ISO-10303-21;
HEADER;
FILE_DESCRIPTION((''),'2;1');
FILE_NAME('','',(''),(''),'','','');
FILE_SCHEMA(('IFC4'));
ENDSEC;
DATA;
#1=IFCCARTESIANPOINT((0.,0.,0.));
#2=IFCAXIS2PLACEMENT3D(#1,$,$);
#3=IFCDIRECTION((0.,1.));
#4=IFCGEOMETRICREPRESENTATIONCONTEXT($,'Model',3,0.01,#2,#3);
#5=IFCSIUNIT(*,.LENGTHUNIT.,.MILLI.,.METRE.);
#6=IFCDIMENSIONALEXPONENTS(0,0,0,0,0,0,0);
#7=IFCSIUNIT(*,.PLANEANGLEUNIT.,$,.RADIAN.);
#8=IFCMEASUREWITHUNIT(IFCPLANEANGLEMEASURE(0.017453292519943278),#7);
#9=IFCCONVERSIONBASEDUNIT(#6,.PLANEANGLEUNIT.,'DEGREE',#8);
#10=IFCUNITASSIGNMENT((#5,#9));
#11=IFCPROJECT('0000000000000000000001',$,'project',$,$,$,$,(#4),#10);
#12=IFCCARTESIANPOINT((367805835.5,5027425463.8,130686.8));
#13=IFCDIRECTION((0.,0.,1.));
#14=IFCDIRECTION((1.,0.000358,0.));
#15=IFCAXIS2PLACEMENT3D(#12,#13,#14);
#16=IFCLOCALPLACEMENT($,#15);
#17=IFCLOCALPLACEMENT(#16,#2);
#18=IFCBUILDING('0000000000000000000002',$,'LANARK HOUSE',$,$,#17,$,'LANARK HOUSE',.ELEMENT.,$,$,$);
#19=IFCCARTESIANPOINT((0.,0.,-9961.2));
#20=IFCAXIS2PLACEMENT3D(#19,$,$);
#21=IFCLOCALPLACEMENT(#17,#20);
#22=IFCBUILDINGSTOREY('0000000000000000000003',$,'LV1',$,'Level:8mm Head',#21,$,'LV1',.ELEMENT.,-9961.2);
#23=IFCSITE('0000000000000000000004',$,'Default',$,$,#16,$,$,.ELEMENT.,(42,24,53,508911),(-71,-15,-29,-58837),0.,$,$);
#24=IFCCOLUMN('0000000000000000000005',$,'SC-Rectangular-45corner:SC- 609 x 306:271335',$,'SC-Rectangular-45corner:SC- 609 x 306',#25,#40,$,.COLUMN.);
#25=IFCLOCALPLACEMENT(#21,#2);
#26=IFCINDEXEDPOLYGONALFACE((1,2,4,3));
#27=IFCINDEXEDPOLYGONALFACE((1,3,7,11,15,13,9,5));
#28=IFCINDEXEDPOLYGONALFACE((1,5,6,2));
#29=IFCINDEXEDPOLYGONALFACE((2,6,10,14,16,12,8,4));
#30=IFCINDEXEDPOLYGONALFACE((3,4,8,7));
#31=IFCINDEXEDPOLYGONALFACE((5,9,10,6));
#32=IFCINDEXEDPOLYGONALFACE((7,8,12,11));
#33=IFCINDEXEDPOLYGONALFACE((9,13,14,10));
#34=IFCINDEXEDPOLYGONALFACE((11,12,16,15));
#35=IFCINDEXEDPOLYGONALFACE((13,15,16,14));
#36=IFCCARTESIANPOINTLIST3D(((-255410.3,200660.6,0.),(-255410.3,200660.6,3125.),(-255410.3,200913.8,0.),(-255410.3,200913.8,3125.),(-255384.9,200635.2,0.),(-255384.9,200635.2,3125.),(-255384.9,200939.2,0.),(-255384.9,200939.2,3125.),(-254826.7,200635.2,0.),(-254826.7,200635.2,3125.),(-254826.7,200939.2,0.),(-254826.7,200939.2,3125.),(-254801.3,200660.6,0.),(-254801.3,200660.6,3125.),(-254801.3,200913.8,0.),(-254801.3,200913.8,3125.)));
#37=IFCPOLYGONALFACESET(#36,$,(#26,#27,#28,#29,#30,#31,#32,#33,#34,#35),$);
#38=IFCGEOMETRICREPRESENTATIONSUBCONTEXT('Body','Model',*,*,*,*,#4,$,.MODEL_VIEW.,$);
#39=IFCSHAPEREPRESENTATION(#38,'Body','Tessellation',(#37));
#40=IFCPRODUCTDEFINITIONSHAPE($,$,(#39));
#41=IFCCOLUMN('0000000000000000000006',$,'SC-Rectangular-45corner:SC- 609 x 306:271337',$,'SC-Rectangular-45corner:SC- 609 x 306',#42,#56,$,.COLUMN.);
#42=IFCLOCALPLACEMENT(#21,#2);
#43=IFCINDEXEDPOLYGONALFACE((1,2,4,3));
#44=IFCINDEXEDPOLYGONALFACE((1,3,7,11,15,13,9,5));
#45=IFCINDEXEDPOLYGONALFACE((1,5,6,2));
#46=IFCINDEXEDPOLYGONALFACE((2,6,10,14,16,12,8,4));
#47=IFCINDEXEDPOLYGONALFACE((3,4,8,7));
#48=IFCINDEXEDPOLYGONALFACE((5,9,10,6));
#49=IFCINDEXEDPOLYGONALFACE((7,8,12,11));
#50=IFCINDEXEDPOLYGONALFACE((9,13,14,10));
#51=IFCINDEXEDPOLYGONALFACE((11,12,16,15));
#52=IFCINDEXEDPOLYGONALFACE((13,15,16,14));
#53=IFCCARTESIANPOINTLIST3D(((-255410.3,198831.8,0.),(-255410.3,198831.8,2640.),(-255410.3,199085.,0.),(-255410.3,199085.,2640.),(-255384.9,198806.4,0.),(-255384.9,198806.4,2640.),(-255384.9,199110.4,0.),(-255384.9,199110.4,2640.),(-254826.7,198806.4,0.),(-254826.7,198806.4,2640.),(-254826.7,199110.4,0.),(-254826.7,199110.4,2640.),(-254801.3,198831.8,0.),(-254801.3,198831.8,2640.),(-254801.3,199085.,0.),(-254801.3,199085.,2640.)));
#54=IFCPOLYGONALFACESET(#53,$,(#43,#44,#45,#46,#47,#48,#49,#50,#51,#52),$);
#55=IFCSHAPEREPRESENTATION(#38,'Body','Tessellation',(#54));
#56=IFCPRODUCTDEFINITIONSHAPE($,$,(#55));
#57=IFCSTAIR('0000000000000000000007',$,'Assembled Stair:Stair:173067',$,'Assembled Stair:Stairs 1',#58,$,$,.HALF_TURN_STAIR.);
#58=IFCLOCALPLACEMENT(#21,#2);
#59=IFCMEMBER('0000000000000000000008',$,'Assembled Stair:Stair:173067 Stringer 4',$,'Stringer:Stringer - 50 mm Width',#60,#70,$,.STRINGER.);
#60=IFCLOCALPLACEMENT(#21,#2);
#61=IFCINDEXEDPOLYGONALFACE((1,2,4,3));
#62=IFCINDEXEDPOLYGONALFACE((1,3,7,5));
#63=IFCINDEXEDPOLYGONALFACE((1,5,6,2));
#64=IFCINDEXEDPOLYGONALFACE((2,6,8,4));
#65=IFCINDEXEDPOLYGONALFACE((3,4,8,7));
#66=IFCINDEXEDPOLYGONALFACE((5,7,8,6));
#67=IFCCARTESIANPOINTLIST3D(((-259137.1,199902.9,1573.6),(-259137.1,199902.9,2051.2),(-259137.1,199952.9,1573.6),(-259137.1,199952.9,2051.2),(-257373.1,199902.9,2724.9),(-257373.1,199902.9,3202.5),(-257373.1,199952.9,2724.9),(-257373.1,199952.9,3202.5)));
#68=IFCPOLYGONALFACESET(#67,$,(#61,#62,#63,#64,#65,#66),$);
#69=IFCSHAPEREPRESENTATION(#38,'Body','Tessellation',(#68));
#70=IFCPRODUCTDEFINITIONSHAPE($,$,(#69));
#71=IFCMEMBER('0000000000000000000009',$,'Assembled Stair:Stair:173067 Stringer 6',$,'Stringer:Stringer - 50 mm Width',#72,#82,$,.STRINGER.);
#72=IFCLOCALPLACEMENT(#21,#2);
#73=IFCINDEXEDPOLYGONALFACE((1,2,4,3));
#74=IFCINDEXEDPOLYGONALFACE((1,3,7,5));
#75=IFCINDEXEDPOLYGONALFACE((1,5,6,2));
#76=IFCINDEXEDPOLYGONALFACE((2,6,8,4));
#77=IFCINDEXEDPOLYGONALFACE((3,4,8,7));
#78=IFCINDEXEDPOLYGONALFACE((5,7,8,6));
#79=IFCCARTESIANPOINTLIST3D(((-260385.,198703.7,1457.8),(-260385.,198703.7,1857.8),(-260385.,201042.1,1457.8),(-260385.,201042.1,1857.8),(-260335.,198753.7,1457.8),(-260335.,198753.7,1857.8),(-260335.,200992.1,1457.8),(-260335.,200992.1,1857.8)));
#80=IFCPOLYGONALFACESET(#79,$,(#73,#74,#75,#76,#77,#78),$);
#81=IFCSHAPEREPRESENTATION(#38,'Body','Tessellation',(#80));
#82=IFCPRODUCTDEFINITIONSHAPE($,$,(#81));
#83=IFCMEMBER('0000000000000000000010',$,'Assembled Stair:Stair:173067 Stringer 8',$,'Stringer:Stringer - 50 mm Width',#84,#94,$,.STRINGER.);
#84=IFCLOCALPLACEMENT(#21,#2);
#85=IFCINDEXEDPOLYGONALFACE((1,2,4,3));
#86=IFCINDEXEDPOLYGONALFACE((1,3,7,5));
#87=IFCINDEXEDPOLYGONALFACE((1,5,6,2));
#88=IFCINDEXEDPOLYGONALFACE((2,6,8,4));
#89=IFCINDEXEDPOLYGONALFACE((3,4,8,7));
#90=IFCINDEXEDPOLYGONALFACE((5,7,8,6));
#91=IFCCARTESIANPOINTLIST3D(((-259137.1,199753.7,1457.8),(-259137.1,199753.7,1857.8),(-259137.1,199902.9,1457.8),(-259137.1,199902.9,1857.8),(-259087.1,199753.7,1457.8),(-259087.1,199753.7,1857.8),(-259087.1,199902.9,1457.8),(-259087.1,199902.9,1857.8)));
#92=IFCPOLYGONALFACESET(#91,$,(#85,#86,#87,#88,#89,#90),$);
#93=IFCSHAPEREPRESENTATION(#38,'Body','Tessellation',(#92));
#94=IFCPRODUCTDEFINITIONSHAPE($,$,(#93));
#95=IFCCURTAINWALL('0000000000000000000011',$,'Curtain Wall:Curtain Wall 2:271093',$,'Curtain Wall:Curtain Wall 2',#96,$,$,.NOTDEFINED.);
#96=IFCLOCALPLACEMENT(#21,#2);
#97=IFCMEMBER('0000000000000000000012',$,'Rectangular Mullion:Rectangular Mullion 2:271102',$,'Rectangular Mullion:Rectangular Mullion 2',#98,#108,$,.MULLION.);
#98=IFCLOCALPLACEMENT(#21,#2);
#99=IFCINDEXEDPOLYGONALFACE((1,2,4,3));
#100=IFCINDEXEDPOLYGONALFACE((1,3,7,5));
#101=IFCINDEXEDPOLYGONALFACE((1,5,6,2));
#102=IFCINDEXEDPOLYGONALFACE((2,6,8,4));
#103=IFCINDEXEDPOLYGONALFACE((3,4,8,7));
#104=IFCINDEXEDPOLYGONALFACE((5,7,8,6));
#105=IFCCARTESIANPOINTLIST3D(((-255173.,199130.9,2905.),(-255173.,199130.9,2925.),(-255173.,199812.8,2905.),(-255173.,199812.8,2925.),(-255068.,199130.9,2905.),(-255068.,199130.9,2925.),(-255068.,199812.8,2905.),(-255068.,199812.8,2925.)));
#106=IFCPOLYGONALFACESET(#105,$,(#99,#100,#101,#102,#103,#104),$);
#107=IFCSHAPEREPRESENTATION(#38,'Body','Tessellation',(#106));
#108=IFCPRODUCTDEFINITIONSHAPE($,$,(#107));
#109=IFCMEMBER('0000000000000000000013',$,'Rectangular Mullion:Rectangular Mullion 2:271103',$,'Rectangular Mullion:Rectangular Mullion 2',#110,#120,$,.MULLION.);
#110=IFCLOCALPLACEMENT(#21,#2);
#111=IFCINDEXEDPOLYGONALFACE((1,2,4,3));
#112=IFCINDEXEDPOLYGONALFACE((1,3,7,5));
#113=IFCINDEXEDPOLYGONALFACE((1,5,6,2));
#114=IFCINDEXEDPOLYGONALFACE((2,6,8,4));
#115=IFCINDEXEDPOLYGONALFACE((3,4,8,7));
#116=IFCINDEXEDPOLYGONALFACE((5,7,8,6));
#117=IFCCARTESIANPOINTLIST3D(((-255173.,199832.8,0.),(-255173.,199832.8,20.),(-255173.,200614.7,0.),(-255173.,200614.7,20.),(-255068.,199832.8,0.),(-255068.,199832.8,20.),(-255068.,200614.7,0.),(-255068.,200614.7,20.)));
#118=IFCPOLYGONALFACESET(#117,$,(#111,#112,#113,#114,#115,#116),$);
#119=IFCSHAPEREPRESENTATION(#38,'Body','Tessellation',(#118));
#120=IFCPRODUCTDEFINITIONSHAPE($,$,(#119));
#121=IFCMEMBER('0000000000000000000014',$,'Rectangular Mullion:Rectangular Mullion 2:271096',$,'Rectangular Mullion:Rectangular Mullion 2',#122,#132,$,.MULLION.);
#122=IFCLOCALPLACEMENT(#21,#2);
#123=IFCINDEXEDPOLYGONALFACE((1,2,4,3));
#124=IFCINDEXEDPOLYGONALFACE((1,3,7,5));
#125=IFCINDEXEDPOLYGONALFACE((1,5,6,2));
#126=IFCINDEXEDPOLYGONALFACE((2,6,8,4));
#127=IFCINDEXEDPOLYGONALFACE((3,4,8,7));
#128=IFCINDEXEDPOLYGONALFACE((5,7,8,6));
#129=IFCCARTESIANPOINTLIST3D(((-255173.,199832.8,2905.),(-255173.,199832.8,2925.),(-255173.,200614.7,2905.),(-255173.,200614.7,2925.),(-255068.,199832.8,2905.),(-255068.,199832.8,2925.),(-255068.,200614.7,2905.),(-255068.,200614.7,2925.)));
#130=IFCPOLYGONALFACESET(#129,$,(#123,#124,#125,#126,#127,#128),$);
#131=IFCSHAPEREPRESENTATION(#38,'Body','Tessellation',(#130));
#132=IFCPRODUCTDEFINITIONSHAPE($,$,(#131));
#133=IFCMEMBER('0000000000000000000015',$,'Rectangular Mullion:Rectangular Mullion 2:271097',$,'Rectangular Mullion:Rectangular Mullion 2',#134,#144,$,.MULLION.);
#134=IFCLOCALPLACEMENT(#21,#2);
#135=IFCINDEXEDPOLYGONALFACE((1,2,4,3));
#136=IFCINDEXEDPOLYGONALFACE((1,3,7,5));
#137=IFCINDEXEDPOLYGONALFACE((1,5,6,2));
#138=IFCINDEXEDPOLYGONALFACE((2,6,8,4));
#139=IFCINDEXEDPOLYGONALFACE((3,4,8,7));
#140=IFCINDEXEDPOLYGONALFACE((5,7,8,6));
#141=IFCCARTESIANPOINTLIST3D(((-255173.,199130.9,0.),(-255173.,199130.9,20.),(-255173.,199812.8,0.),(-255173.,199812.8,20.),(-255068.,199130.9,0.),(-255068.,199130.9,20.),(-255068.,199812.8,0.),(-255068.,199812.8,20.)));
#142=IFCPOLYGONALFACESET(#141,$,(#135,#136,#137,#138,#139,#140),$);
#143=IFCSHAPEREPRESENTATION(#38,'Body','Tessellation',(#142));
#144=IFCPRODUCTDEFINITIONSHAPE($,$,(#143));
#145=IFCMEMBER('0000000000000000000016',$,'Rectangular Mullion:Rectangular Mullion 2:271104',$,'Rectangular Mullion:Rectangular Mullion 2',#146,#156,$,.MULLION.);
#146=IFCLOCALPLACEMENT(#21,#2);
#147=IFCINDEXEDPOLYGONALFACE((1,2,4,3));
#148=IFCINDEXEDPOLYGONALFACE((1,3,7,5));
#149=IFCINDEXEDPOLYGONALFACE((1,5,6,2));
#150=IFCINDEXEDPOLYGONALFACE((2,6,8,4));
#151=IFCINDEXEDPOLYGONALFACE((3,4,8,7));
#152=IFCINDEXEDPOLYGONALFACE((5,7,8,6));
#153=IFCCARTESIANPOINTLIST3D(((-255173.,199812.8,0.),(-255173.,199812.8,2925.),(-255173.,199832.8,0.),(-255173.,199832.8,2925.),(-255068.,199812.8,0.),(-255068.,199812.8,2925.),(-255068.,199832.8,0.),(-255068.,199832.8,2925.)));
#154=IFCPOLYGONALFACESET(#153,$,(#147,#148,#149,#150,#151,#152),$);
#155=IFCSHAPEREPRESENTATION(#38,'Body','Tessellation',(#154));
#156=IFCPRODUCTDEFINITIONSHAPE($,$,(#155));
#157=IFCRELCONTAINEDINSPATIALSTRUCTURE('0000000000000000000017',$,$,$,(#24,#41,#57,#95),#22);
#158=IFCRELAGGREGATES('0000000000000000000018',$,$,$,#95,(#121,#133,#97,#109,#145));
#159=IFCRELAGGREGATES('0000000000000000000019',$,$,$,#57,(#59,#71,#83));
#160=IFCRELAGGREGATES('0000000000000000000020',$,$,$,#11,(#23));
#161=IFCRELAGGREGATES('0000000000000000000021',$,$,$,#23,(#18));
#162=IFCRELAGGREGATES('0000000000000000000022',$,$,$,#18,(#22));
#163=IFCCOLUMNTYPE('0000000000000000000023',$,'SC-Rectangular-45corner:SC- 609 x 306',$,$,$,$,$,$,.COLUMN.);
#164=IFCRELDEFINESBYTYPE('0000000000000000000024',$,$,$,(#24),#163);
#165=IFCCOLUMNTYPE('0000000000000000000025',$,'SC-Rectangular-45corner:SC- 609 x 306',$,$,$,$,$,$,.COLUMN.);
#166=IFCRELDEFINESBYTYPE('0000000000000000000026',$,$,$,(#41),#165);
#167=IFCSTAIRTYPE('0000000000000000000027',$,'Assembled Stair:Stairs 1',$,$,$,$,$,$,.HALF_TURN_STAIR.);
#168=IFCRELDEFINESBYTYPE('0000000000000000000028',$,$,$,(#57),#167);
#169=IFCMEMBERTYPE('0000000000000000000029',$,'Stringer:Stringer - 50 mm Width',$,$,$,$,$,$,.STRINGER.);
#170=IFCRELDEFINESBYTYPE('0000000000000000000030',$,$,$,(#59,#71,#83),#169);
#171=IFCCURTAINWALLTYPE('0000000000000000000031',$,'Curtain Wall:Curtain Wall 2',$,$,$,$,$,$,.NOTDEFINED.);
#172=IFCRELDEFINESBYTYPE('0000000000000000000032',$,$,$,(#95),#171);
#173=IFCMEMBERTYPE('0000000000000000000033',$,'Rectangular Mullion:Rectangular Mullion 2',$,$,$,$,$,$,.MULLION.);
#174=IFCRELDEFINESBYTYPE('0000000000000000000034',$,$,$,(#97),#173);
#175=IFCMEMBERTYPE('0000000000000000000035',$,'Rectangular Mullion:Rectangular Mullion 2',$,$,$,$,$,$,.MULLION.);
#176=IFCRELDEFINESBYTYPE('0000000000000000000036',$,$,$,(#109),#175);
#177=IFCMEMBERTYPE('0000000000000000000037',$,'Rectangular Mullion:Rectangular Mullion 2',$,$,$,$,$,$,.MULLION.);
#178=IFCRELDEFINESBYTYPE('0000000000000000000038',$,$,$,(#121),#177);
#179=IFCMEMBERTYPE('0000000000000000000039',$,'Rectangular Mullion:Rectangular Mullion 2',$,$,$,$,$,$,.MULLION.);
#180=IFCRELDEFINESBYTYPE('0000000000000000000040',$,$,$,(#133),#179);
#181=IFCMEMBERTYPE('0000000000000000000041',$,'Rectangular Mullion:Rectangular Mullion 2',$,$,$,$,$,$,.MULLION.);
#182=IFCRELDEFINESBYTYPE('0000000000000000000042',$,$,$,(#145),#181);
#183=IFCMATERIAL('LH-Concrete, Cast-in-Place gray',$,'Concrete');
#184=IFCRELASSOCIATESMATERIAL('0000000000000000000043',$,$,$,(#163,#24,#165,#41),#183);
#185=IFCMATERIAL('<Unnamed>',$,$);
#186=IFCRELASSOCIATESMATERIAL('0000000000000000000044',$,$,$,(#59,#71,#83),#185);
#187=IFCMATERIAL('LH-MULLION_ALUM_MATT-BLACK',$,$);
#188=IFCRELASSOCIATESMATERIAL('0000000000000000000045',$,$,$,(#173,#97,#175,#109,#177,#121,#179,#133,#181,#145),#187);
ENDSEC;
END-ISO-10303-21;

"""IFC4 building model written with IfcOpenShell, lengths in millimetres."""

from ifc_helpers import new_model, entity, si_unit, converted_unit, direction, frame, origin, place, context, subcontext, project, spatial, indexed_curve, outline, extrude, source, transform, mapped, material, type_object, type_shapes, element, aggregate, save


model = new_model("IFC4")

# Units and contexts
model_context = context("Model", 3, precision=0.01, world=origin(), true_north=direction((0.0, 1.0)))
body_context = subcontext(model_context, "Body", "Model", "MODEL_VIEW")
ifc_project = project(units=[si_unit("LENGTHUNIT", "METRE", prefix="MILLI"), converted_unit("PLANEANGLEUNIT", "DEGREE", entity("IfcPlaneAngleMeasure", 0.017453292519943278), si_unit("PLANEANGLEUNIT", "RADIAN"), dimensions=[0, 0, 0, 0, 0, 0, 0])], contexts=[model_context])

# Site, building, storey
site_placement = place(None, frame((367805835.5, 5027425463.8, 130686.8), z_axis=(0.0, 0.0, 1.0), x_axis=(1.0, 0.000358, 0.0)))
site = spatial("IfcSite", under=ifc_project, at=site_placement, Name="Default", CompositionType="ELEMENT", RefLatitude=(42, 24, 53, 508911), RefLongitude=(-71, -15, -29, -58837), RefElevation=0.0)
building_placement = place(site_placement, origin())
building = spatial("IfcBuilding", under=site, at=building_placement, Name="LANARK HOUSE", LongName="LANARK HOUSE", CompositionType="ELEMENT")
storey_placement = place(building_placement, frame((0.0, 0.0, -9961.2)))
storey = spatial("IfcBuildingStorey", under=building, at=storey_placement, Name="LV1", ObjectType="Level:8mm Head", LongName="LV1", CompositionType="ELEMENT", Elevation=-9961.2)

# Columns
ifc_material_1 = material(Name="LH-Concrete, Cast-in-Place gray", Category="Concrete")
column_type_1 = type_object("IfcColumnType", Name="SC-Rectangular-45corner:SC- 609 x 306", PredefinedType="COLUMN", material=ifc_material_1)
shared_shape_1 = source(origin(), body_context, "Body", "SweptSolid", [
    extrude(outline(indexed_curve([(-279.1, -152.0), (279.1, -152.0), (304.5, -126.6), (304.5, 126.6), (279.1, 152.0), (-279.1, 152.0), (-304.5, 126.6), (-304.5, -126.6), (-279.1, -152.0)], self_intersect=False)), frame((0.0, 0.0, -9961.2), z_axis=(0.0, 0.0, 1.0), x_axis=(-1.0, 0.0, 0.0)), (0.0, 0.0, 1.0), 3125.0),
])
type_shapes(column_type_1, [shared_shape_1])
column_1_placement = place(storey_placement, frame((-255105.8, 200787.2, 9961.2)))
element("IfcColumn", 1, at=column_1_placement, inside=storey, type_object=column_type_1, material=ifc_material_1, Name="SC-Rectangular-45corner:SC- 609 x 306:271335", ObjectType="SC-Rectangular-45corner:SC- 609 x 306", PredefinedType="COLUMN", context=body_context, shape_type="MappedRepresentation", body=[
    mapped(shared_shape_1, transform((0.0, 0.0, 0.0), scale=1.0)),
])
column_type_2 = type_object("IfcColumnType", Name="SC-Rectangular-45corner:SC- 609 x 306", PredefinedType="COLUMN", material=ifc_material_1)
shared_shape_2 = source(origin(), body_context, "Body", "SweptSolid", [
    extrude(outline(indexed_curve([(-279.1, -152.0), (279.1, -152.0), (304.5, -126.6), (304.5, 126.6), (279.1, 152.0), (-279.1, 152.0), (-304.5, 126.6), (-304.5, -126.6), (-279.1, -152.0)], self_intersect=False)), frame((0.0, 0.0, -9961.2), z_axis=(0.0, 0.0, 1.0), x_axis=(-1.0, 0.0, 0.0)), (0.0, 0.0, 1.0), 2640.0),
])
type_shapes(column_type_2, [shared_shape_2])
column_2_placement = place(storey_placement, frame((-255105.8, 198958.4, 9961.2)))
element("IfcColumn", 2, at=column_2_placement, inside=storey, type_object=column_type_2, material=ifc_material_1, Name="SC-Rectangular-45corner:SC- 609 x 306:271337", ObjectType="SC-Rectangular-45corner:SC- 609 x 306", PredefinedType="COLUMN", context=body_context, shape_type="MappedRepresentation", body=[
    mapped(shared_shape_2, transform((0.0, 0.0, 0.0), scale=1.0)),
])

# Stair, members
stair_type = type_object("IfcStairType", Name="Assembled Stair:Stairs 1", PredefinedType="HALF_TURN_STAIR")
stair_placement = place(storey_placement, origin())
stair = element("IfcStair", 3, at=stair_placement, inside=storey, type_object=stair_type, Name="Assembled Stair:Stair:173067", ObjectType="Assembled Stair:Stairs 1", PredefinedType="HALF_TURN_STAIR")
ifc_material_2 = material(Name="<Unnamed>")
member_type_1 = type_object("IfcMemberType", Name="Stringer:Stringer - 50 mm Width", PredefinedType="STRINGER")
member_1_placement = place(stair_placement, frame((-259137.1, 199902.9, 1573.6)))
member_1 = element("IfcMember", 4, at=member_1_placement, type_object=member_type_1, material=ifc_material_2, Name="Assembled Stair:Stair:173067 Stringer 4", ObjectType="Stringer:Stringer - 50 mm Width", PredefinedType="STRINGER", context=body_context, shape_type="SweptSolid", body=[
    extrude(outline(indexed_curve([(-922.7, -200.0), (1183.8, -200.0), (922.7, 200.0), (-1183.8, 200.0), (-922.7, -200.0)], self_intersect=False)), frame((882.0, 0.0, 814.5), z_axis=(0.0, 1.0, 0.0), x_axis=(0.837419, 0.0, 0.546561)), (0.0, 0.0, 1.0), 50.0),
])
member_2_placement = place(stair_placement, frame((-260385.0, 198703.7, 1457.8)))
member_2 = element("IfcMember", 5, at=member_2_placement, type_object=member_type_1, material=ifc_material_2, Name="Assembled Stair:Stair:173067 Stringer 6", ObjectType="Stringer:Stringer - 50 mm Width", PredefinedType="STRINGER", context=body_context, shape_type="SweptSolid", body=[
    extrude(outline(indexed_curve([(-1169.2, -25.0), (1169.2, -25.0), (1119.2, 25.0), (-1119.2, 25.0), (-1169.2, -25.0)], self_intersect=False)), frame((25.0, 1169.2, 0.0), z_axis=(0.0, 0.0, 1.0), x_axis=(0.0, -1.0, 0.0)), (0.0, 0.0, 1.0), 400.0),
])
member_3_placement = place(stair_placement, frame((-259137.1, 199753.7, 1457.8)))
member_3 = element("IfcMember", 6, at=member_3_placement, type_object=member_type_1, material=ifc_material_2, Name="Assembled Stair:Stair:173067 Stringer 8", ObjectType="Stringer:Stringer - 50 mm Width", PredefinedType="STRINGER", context=body_context, shape_type="SweptSolid", body=[
    extrude(outline(indexed_curve([(-74.6, -25.0), (74.6, -25.0), (74.6, 25.0), (-74.6, 25.0), (-74.6, -25.0)], self_intersect=False)), frame((25.0, 74.6, 0.0), z_axis=(0.0, 0.0, 1.0), x_axis=(0.0, 1.0, 0.0)), (0.0, 0.0, 1.0), 400.0),
])

# Curtain wall, members
curtain_wall_type = type_object("IfcCurtainWallType", Name="Curtain Wall:Curtain Wall 2", PredefinedType="NOTDEFINED")
curtain_wall_placement = place(storey_placement, frame((0.0, 0.0, 9961.2)))
curtain_wall = element("IfcCurtainWall", 7, at=curtain_wall_placement, inside=storey, type_object=curtain_wall_type, Name="Curtain Wall:Curtain Wall 2:271093", ObjectType="Curtain Wall:Curtain Wall 2", PredefinedType="NOTDEFINED")
ifc_material_3 = material(Name="LH-MULLION_ALUM_MATT-BLACK")
member_type_2 = type_object("IfcMemberType", Name="Rectangular Mullion:Rectangular Mullion 2", PredefinedType="MULLION", material=ifc_material_3)
shared_shape_3 = source(origin(), body_context, "Body", "SweptSolid", [
    extrude(outline(indexed_curve([(-10.0, -52.5), (10.0, -52.5), (10.0, 52.5), (-10.0, 52.5), (-10.0, -52.5)], self_intersect=False)), frame((-10.0, -40.0, -681.9), z_axis=(0.0, 0.0, 1.0), x_axis=(-1.0, 0.0, 0.0)), (0.0, 0.0, 1.0), 681.9),
])
type_shapes(member_type_2, [shared_shape_3])
member_4_placement = place(curtain_wall_placement, frame((-255080.5, 199812.8, -7036.2), z_axis=(0.0, 1.0, 0.0), x_axis=(0.0, 0.0, 1.0)))
member_4 = element("IfcMember", 8, at=member_4_placement, type_object=member_type_2, material=ifc_material_3, Name="Rectangular Mullion:Rectangular Mullion 2:271102", ObjectType="Rectangular Mullion:Rectangular Mullion 2", PredefinedType="MULLION", context=body_context, shape_type="MappedRepresentation", body=[
    mapped(shared_shape_3, transform((0.0, 0.0, 0.0), scale=1.0)),
])
member_type_3 = type_object("IfcMemberType", Name="Rectangular Mullion:Rectangular Mullion 2", PredefinedType="MULLION", material=ifc_material_3)
shared_shape_4 = source(origin(), body_context, "Body", "SweptSolid", [
    extrude(outline(indexed_curve([(-10.0, -52.5), (10.0, -52.5), (10.0, 52.5), (-10.0, 52.5), (-10.0, -52.5)], self_intersect=False)), frame((-10.0, -40.0, -781.9), z_axis=(0.0, 0.0, 1.0), x_axis=(-1.0, 0.0, 0.0)), (0.0, 0.0, 1.0), 781.9),
])
type_shapes(member_type_3, [shared_shape_4])
member_5_placement = place(curtain_wall_placement, frame((-255080.5, 199832.8, -9961.2), z_axis=(0.0, -1.0, 0.0), x_axis=(0.0, 0.0, -1.0)))
member_5 = element("IfcMember", 9, at=member_5_placement, type_object=member_type_3, material=ifc_material_3, Name="Rectangular Mullion:Rectangular Mullion 2:271103", ObjectType="Rectangular Mullion:Rectangular Mullion 2", PredefinedType="MULLION", context=body_context, shape_type="MappedRepresentation", body=[
    mapped(shared_shape_4, transform((0.0, 0.0, 0.0), scale=1.0)),
])
member_type_4 = type_object("IfcMemberType", Name="Rectangular Mullion:Rectangular Mullion 2", PredefinedType="MULLION", material=ifc_material_3)
shared_shape_5 = source(origin(), body_context, "Body", "SweptSolid", [
    extrude(outline(indexed_curve([(-10.0, -52.5), (10.0, -52.5), (10.0, 52.5), (-10.0, 52.5), (-10.0, -52.5)], self_intersect=False)), frame((-10.0, -40.0, -781.9), z_axis=(0.0, 0.0, 1.0), x_axis=(-1.0, 0.0, 0.0)), (0.0, 0.0, 1.0), 781.9),
])
type_shapes(member_type_4, [shared_shape_5])
member_6_placement = place(curtain_wall_placement, frame((-255080.5, 200614.7, -7036.2), z_axis=(0.0, 1.0, 0.0), x_axis=(0.0, 0.0, 1.0)))
member_6 = element("IfcMember", 10, at=member_6_placement, type_object=member_type_4, material=ifc_material_3, Name="Rectangular Mullion:Rectangular Mullion 2:271096", ObjectType="Rectangular Mullion:Rectangular Mullion 2", PredefinedType="MULLION", context=body_context, shape_type="MappedRepresentation", body=[
    mapped(shared_shape_5, transform((0.0, 0.0, 0.0), scale=1.0)),
])
member_type_5 = type_object("IfcMemberType", Name="Rectangular Mullion:Rectangular Mullion 2", PredefinedType="MULLION", material=ifc_material_3)
shared_shape_6 = source(origin(), body_context, "Body", "SweptSolid", [
    extrude(outline(indexed_curve([(-10.0, -52.5), (10.0, -52.5), (10.0, 52.5), (-10.0, 52.5), (-10.0, -52.5)], self_intersect=False)), frame((-10.0, -40.0, -681.9), z_axis=(0.0, 0.0, 1.0), x_axis=(-1.0, 0.0, 0.0)), (0.0, 0.0, 1.0), 681.9),
])
type_shapes(member_type_5, [shared_shape_6])
member_7_placement = place(curtain_wall_placement, frame((-255080.5, 199130.9, -9961.2), z_axis=(0.0, -1.0, 0.0), x_axis=(0.0, 0.0, -1.0)))
member_7 = element("IfcMember", 11, at=member_7_placement, type_object=member_type_5, material=ifc_material_3, Name="Rectangular Mullion:Rectangular Mullion 2:271097", ObjectType="Rectangular Mullion:Rectangular Mullion 2", PredefinedType="MULLION", context=body_context, shape_type="MappedRepresentation", body=[
    mapped(shared_shape_6, transform((0.0, 0.0, 0.0), scale=1.0)),
])
member_type_6 = type_object("IfcMemberType", Name="Rectangular Mullion:Rectangular Mullion 2", PredefinedType="MULLION", material=ifc_material_3)
shared_shape_7 = source(origin(), body_context, "Body", "SweptSolid", [
    extrude(outline(indexed_curve([(-10.0, -52.5), (10.0, -52.5), (10.0, 52.5), (-10.0, 52.5), (-10.0, -52.5)], self_intersect=False)), frame((0.0, -40.0, -2925.0), z_axis=(0.0, 0.0, 1.0), x_axis=(-1.0, 0.0, 0.0)), (0.0, 0.0, 1.0), 2925.0),
])
type_shapes(member_type_6, [shared_shape_7])
member_8_placement = place(curtain_wall_placement, frame((-255080.5, 199822.8, -9961.2), z_axis=(0.0, 0.0, -1.0), x_axis=(0.0, 1.0, 0.0)))
member_8 = element("IfcMember", 12, at=member_8_placement, type_object=member_type_6, material=ifc_material_3, Name="Rectangular Mullion:Rectangular Mullion 2:271104", ObjectType="Rectangular Mullion:Rectangular Mullion 2", PredefinedType="MULLION", context=body_context, shape_type="MappedRepresentation", body=[
    mapped(shared_shape_7, transform((0.0, 0.0, 0.0), scale=1.0)),
])

aggregate(curtain_wall, [member_6, member_7, member_4, member_5, member_8])

aggregate(stair, [member_1, member_2, member_3])

save(model, "model.ifc")
